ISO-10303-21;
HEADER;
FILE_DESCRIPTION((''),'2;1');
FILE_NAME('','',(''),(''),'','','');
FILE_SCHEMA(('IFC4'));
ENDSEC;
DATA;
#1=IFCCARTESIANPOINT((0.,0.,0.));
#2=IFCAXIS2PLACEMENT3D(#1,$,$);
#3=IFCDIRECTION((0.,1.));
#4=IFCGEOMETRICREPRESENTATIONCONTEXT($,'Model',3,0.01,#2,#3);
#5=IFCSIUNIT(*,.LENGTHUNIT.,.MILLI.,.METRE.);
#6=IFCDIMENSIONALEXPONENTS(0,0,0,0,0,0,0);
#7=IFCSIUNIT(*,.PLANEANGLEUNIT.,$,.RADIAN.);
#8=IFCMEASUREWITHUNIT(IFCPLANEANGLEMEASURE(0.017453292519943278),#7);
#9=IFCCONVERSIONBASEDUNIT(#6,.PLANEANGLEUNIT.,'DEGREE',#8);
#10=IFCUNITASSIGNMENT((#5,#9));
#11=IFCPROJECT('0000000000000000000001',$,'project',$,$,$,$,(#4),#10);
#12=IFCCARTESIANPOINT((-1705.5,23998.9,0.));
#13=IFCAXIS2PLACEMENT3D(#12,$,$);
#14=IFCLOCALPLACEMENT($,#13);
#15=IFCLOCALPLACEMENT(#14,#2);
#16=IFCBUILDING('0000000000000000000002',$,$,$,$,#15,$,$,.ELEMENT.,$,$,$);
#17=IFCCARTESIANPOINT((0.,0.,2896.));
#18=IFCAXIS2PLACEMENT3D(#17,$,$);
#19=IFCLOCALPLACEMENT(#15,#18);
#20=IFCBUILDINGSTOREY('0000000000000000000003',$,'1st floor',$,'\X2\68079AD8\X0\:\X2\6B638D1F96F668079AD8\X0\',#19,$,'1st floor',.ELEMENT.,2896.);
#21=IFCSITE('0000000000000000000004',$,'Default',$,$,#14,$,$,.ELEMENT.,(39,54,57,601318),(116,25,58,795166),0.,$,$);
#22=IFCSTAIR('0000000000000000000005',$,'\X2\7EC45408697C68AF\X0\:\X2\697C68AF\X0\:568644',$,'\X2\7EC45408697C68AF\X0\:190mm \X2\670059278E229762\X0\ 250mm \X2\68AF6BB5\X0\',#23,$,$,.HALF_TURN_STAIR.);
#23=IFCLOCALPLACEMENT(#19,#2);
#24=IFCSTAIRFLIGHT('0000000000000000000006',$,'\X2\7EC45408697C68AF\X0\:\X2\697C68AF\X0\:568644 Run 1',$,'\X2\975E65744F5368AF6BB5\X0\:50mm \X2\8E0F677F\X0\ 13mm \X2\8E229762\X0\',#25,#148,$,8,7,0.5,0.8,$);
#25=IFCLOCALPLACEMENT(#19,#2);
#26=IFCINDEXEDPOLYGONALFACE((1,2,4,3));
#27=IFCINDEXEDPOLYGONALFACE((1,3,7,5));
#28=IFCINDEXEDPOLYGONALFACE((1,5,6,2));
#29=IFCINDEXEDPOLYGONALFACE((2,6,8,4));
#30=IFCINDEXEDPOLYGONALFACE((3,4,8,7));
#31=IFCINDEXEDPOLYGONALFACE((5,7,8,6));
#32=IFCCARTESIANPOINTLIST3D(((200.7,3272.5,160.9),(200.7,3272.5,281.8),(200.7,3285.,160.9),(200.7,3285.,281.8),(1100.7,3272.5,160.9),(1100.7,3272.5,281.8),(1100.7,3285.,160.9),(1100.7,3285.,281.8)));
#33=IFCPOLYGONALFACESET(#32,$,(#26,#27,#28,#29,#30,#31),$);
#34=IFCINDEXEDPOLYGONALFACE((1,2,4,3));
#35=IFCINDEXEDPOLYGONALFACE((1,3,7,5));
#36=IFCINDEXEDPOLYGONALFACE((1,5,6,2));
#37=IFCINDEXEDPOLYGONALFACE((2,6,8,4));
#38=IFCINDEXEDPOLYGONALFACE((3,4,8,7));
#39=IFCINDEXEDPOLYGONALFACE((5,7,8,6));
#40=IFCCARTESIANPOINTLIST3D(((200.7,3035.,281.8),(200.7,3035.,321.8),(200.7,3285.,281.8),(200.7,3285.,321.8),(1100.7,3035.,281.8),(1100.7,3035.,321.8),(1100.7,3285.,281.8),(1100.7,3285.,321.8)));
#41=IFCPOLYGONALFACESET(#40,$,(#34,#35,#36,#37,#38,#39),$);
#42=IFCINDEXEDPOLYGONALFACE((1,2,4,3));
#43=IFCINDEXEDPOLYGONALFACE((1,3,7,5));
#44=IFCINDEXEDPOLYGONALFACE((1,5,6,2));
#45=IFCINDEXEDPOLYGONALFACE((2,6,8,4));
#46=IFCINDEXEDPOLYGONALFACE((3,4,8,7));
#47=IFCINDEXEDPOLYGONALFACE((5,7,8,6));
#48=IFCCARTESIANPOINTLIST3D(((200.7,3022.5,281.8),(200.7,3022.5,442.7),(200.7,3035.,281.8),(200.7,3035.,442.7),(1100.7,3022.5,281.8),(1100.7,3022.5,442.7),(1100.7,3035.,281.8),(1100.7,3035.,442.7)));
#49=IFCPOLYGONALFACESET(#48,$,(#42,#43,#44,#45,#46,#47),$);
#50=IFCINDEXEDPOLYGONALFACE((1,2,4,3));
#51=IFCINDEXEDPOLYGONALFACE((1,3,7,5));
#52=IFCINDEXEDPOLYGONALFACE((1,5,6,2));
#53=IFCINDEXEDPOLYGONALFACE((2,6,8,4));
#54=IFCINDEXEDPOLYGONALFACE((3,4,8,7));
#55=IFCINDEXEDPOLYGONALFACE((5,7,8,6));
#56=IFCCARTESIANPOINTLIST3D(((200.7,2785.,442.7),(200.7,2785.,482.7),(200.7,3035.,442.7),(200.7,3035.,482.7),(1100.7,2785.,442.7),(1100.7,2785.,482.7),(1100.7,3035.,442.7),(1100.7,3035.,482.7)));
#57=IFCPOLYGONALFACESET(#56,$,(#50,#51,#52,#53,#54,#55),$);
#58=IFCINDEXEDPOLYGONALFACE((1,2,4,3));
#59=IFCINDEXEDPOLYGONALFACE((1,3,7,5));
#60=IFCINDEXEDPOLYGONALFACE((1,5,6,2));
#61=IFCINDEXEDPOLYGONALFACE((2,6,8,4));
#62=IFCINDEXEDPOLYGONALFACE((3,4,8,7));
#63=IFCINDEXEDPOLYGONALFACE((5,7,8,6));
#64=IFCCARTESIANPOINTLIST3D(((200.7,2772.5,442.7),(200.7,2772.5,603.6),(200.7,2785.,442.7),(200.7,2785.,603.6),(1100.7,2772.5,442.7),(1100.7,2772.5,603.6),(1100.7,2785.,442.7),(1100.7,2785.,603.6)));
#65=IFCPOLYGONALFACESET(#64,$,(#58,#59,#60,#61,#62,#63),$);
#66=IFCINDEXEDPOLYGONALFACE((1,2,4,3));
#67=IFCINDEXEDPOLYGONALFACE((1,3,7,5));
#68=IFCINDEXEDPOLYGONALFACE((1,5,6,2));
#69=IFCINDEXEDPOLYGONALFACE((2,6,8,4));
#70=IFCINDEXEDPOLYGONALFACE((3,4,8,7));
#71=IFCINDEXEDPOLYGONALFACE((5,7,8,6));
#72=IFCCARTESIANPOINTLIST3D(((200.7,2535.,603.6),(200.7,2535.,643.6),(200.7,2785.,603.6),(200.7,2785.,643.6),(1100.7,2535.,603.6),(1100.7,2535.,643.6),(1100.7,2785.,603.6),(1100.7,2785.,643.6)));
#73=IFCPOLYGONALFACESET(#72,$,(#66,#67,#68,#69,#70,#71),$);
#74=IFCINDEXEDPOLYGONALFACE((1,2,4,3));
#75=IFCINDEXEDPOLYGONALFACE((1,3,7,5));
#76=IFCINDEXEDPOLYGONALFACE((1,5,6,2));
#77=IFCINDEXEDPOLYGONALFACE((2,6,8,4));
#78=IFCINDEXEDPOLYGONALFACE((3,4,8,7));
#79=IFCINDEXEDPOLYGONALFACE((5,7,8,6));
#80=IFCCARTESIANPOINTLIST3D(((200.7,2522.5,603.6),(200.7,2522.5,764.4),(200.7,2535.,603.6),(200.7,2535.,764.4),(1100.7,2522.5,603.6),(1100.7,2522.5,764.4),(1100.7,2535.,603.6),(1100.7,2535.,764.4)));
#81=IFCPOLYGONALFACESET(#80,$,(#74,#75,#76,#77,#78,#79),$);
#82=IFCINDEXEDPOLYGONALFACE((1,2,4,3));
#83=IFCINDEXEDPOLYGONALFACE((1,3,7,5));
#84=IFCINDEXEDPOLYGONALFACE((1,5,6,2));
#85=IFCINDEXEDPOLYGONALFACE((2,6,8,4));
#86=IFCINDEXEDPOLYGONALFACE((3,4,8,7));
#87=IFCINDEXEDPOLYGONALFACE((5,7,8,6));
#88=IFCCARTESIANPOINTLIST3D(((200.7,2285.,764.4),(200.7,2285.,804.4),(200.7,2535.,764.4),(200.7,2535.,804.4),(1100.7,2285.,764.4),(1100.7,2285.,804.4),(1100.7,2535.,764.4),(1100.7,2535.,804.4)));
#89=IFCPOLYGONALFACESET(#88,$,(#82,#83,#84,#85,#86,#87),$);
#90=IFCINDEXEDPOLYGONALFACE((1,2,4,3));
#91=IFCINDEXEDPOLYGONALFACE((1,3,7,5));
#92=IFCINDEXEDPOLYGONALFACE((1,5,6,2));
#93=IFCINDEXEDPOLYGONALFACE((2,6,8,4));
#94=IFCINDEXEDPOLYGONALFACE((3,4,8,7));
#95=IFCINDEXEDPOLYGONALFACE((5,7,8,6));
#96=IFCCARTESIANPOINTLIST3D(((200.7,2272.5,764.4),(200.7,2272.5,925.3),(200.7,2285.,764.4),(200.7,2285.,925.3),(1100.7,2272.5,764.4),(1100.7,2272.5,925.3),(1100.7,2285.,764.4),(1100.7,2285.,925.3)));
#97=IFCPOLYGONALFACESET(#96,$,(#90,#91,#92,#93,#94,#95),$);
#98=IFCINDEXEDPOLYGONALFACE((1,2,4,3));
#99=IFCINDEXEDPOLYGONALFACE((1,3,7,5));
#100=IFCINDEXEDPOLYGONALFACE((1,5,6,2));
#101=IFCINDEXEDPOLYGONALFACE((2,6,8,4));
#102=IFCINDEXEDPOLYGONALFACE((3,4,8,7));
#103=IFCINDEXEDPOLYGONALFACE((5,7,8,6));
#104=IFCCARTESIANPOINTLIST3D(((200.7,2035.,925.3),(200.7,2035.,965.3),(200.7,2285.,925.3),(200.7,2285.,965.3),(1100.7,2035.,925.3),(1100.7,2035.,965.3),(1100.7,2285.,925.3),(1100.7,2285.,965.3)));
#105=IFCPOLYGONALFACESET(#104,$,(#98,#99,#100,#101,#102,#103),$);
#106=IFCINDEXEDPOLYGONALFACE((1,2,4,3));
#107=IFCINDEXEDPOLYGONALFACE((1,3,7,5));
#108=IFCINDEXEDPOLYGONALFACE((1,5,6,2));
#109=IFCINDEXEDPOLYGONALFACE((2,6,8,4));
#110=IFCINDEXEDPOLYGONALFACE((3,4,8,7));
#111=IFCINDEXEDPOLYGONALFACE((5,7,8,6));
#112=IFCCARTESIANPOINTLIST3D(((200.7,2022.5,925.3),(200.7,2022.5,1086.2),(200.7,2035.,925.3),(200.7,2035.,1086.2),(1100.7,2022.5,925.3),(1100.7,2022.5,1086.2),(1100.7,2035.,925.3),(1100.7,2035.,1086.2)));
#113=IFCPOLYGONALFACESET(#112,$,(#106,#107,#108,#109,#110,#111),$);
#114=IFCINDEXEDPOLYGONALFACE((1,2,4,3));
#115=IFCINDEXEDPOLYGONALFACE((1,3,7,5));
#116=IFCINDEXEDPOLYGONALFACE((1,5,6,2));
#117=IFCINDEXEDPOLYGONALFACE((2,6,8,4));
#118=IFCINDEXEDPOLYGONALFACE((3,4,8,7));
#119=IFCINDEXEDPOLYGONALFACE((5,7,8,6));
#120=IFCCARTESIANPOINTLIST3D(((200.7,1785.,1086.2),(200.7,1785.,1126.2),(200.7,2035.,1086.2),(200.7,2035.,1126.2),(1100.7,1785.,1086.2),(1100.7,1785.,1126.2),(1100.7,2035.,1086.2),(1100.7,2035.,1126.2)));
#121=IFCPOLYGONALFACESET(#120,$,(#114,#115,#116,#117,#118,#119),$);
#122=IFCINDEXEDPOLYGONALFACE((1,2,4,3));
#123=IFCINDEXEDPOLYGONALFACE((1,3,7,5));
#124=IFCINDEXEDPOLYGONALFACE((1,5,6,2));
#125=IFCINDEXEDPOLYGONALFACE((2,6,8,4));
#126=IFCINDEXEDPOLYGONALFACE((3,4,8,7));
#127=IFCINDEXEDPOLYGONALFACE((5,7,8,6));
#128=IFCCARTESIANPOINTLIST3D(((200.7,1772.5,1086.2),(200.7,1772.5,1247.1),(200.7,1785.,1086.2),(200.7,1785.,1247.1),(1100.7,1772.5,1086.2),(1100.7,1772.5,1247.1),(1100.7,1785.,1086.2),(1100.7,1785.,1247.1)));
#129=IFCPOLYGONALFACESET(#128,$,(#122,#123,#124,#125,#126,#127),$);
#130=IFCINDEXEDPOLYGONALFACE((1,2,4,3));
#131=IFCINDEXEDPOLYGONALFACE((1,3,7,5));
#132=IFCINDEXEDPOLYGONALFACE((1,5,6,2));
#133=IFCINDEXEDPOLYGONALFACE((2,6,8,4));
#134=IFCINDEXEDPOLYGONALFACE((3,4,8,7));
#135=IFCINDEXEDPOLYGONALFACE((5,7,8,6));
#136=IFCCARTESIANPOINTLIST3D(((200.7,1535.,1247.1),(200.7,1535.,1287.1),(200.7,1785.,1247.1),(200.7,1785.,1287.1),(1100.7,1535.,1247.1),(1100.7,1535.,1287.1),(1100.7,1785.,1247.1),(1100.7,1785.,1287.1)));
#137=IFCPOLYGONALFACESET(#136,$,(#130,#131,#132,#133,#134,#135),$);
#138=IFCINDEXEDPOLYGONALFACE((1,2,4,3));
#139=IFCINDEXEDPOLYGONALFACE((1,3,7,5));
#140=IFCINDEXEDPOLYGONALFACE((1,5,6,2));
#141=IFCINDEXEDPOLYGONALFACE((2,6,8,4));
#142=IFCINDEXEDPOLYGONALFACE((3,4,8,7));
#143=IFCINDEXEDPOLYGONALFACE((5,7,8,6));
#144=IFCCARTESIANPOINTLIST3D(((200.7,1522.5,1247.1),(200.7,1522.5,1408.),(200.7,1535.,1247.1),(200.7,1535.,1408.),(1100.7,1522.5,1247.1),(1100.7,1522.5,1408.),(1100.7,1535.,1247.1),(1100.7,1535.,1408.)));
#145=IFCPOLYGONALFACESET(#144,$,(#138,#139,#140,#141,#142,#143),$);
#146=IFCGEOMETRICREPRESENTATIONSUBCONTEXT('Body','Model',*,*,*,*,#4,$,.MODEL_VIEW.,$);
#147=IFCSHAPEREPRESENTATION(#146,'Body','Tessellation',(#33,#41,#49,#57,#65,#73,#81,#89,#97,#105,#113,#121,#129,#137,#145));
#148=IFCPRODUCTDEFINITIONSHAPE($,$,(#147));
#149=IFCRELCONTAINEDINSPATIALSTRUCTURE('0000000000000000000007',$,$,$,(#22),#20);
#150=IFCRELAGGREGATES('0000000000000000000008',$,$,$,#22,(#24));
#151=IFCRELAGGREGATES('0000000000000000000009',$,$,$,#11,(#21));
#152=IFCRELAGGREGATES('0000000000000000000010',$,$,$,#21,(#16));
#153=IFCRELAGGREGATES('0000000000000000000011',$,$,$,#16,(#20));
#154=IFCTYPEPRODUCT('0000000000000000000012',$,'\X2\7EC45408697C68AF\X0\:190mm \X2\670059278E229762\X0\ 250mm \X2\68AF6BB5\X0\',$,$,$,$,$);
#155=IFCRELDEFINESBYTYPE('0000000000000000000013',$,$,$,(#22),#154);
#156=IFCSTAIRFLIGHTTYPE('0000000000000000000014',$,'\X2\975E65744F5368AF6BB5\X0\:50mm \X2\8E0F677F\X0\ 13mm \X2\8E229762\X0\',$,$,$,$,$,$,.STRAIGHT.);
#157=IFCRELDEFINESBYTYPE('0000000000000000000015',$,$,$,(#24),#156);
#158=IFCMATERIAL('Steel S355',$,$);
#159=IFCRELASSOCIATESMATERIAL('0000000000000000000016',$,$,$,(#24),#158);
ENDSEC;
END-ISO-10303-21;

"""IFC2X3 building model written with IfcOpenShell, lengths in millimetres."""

from ifc_helpers import new_model, entity, si_unit, converted_unit, direction, frame, frame_2d, origin, origin_2d_with_axis, place, context, subcontext, project, spatial, rectangle, extrude, material, type_object, element, aggregate, save


model = new_model("IFC2X3")

# Units and contexts
model_context = context("Model", 3, precision=0.01, world=origin(), true_north=direction((0.0, 1.0)))
body_context = subcontext(model_context, "Body", "Model", "MODEL_VIEW")
ifc_project = project(units=[si_unit("LENGTHUNIT", "METRE", prefix="MILLI"), converted_unit("PLANEANGLEUNIT", "DEGREE", entity("IfcPlaneAngleMeasure", 0.017453292519943278), si_unit("PLANEANGLEUNIT", "RADIAN"), dimensions=[0, 0, 0, 0, 0, 0, 0])], contexts=[model_context])

# Site, building, storey
site_placement = place(None, frame((-1705.5, 23998.9, 0.0)))
site = spatial("IfcSite", under=ifc_project, at=site_placement, Name="Default", CompositionType="ELEMENT", RefLatitude=(39, 54, 57, 601318), RefLongitude=(116, 25, 58, 795166), RefElevation=0.0)
building_placement = place(site_placement, origin())
building = spatial("IfcBuilding", under=site, at=building_placement, CompositionType="ELEMENT")
storey_placement = place(building_placement, frame((0.0, 0.0, 2896.0)))
storey = spatial("IfcBuildingStorey", under=building, at=storey_placement, Name="1st floor", ObjectType="标高:正负零标高", LongName="1st floor", CompositionType="ELEMENT", Elevation=2896.0)

# Stair
type_product = type_object("IfcTypeProduct", Name="组合楼梯:190mm 最大踢面 250mm 梯段")
stair_placement = place(storey_placement, origin())
stair = element("IfcStair", 1, at=stair_placement, inside=storey, type_object=type_product, Name="组合楼梯:楼梯:568644", ObjectType="组合楼梯:190mm 最大踢面 250mm 梯段", ShapeType="HALF_TURN_STAIR")
ifc_material_1 = material(Name="Steel S355")

# Stair flight
stair_flight_type = type_object("IfcStairFlightType", Name="非整体梯段:50mm 踏板 13mm 踢面", PredefinedType="STRAIGHT")
stair_flight_1_placement = place(stair_placement, origin())
stair_flight_1 = element("IfcStairFlight", 2, at=stair_flight_1_placement, type_object=stair_flight_type, material=ifc_material_1, Name="组合楼梯:楼梯:568644 Run 1", ObjectType="非整体梯段:50mm 踏板 13mm 踢面", NumberOfRiser=8, NumberOfTreads=7, RiserHeight=0.5, TreadLength=0.8, context=body_context, shape_type="SweptSolid", body=[
    extrude(rectangle(XDim=900.0, YDim=12.5, at=frame_2d((0.0, 0.0), x_axis=(1.0, 0.0))), frame((650.7, 3278.7, 160.9)), (0.0, 0.0, 1.0), 120.9),
    extrude(rectangle(XDim=250.0, YDim=900.0, at=frame_2d((0.0, 0.0), x_axis=(1.0, 0.0))), frame((650.7, 3160.0, 281.8), z_axis=(0.0, 0.0, 1.0), x_axis=(0.0, 1.0, 0.0)), (0.0, 0.0, 1.0), 40.0),
    extrude(rectangle(XDim=900.0, YDim=12.5, at=origin_2d_with_axis()), frame((650.7, 3028.7, 281.8)), (0.0, 0.0, 1.0), 160.9),
    extrude(rectangle(XDim=250.0, YDim=900.0, at=origin_2d_with_axis()), frame((650.7, 2910.0, 442.7), z_axis=(0.0, 0.0, 1.0), x_axis=(0.0, 1.0, 0.0)), (0.0, 0.0, 1.0), 40.0),
    extrude(rectangle(XDim=900.0, YDim=12.5, at=origin_2d_with_axis()), frame((650.7, 2778.7, 442.7)), (0.0, 0.0, 1.0), 160.9),
    extrude(rectangle(XDim=250.0, YDim=900.0, at=origin_2d_with_axis()), frame((650.7, 2660.0, 603.6), z_axis=(0.0, 0.0, 1.0), x_axis=(0.0, 1.0, 0.0)), (0.0, 0.0, 1.0), 40.0),
    extrude(rectangle(XDim=900.0, YDim=12.5, at=origin_2d_with_axis()), frame((650.7, 2528.7, 603.6)), (0.0, 0.0, 1.0), 160.9),
    extrude(rectangle(XDim=250.0, YDim=900.0, at=origin_2d_with_axis()), frame((650.7, 2410.0, 764.4), z_axis=(0.0, 0.0, 1.0), x_axis=(0.0, 1.0, 0.0)), (0.0, 0.0, 1.0), 40.0),
    extrude(rectangle(XDim=900.0, YDim=12.5, at=origin_2d_with_axis()), frame((650.7, 2278.7, 764.4)), (0.0, 0.0, 1.0), 160.9),
    extrude(rectangle(XDim=250.0, YDim=900.0, at=frame_2d((0.0, 0.0), x_axis=(1.0, 0.0))), frame((650.7, 2160.0, 925.3), z_axis=(0.0, 0.0, 1.0), x_axis=(0.0, 1.0, 0.0)), (0.0, 0.0, 1.0), 40.0),
    extrude(rectangle(XDim=900.0, YDim=12.5, at=origin_2d_with_axis()), frame((650.7, 2028.7, 925.3)), (0.0, 0.0, 1.0), 160.9),
    extrude(rectangle(XDim=250.0, YDim=900.0, at=frame_2d((0.0, 0.0), x_axis=(1.0, 0.0))), frame((650.7, 1910.0, 1086.2), z_axis=(0.0, 0.0, 1.0), x_axis=(0.0, 1.0, 0.0)), (0.0, 0.0, 1.0), 40.0),
    extrude(rectangle(XDim=900.0, YDim=12.5, at=origin_2d_with_axis()), frame((650.7, 1778.7, 1086.2)), (0.0, 0.0, 1.0), 160.9),
    extrude(rectangle(XDim=250.0, YDim=900.0, at=frame_2d((0.0, 0.0), x_axis=(1.0, 0.0))), frame((650.7, 1660.0, 1247.1), z_axis=(0.0, 0.0, 1.0), x_axis=(0.0, 1.0, 0.0)), (0.0, 0.0, 1.0), 40.0),
    extrude(rectangle(XDim=900.0, YDim=12.5, at=frame_2d((0.0, 0.0), x_axis=(1.0, 0.0))), frame((650.7, 1528.7, 1247.1)), (0.0, 0.0, 1.0), 160.9),
])
aggregate(stair, [stair_flight_1])

save(model, "model.ifc")
